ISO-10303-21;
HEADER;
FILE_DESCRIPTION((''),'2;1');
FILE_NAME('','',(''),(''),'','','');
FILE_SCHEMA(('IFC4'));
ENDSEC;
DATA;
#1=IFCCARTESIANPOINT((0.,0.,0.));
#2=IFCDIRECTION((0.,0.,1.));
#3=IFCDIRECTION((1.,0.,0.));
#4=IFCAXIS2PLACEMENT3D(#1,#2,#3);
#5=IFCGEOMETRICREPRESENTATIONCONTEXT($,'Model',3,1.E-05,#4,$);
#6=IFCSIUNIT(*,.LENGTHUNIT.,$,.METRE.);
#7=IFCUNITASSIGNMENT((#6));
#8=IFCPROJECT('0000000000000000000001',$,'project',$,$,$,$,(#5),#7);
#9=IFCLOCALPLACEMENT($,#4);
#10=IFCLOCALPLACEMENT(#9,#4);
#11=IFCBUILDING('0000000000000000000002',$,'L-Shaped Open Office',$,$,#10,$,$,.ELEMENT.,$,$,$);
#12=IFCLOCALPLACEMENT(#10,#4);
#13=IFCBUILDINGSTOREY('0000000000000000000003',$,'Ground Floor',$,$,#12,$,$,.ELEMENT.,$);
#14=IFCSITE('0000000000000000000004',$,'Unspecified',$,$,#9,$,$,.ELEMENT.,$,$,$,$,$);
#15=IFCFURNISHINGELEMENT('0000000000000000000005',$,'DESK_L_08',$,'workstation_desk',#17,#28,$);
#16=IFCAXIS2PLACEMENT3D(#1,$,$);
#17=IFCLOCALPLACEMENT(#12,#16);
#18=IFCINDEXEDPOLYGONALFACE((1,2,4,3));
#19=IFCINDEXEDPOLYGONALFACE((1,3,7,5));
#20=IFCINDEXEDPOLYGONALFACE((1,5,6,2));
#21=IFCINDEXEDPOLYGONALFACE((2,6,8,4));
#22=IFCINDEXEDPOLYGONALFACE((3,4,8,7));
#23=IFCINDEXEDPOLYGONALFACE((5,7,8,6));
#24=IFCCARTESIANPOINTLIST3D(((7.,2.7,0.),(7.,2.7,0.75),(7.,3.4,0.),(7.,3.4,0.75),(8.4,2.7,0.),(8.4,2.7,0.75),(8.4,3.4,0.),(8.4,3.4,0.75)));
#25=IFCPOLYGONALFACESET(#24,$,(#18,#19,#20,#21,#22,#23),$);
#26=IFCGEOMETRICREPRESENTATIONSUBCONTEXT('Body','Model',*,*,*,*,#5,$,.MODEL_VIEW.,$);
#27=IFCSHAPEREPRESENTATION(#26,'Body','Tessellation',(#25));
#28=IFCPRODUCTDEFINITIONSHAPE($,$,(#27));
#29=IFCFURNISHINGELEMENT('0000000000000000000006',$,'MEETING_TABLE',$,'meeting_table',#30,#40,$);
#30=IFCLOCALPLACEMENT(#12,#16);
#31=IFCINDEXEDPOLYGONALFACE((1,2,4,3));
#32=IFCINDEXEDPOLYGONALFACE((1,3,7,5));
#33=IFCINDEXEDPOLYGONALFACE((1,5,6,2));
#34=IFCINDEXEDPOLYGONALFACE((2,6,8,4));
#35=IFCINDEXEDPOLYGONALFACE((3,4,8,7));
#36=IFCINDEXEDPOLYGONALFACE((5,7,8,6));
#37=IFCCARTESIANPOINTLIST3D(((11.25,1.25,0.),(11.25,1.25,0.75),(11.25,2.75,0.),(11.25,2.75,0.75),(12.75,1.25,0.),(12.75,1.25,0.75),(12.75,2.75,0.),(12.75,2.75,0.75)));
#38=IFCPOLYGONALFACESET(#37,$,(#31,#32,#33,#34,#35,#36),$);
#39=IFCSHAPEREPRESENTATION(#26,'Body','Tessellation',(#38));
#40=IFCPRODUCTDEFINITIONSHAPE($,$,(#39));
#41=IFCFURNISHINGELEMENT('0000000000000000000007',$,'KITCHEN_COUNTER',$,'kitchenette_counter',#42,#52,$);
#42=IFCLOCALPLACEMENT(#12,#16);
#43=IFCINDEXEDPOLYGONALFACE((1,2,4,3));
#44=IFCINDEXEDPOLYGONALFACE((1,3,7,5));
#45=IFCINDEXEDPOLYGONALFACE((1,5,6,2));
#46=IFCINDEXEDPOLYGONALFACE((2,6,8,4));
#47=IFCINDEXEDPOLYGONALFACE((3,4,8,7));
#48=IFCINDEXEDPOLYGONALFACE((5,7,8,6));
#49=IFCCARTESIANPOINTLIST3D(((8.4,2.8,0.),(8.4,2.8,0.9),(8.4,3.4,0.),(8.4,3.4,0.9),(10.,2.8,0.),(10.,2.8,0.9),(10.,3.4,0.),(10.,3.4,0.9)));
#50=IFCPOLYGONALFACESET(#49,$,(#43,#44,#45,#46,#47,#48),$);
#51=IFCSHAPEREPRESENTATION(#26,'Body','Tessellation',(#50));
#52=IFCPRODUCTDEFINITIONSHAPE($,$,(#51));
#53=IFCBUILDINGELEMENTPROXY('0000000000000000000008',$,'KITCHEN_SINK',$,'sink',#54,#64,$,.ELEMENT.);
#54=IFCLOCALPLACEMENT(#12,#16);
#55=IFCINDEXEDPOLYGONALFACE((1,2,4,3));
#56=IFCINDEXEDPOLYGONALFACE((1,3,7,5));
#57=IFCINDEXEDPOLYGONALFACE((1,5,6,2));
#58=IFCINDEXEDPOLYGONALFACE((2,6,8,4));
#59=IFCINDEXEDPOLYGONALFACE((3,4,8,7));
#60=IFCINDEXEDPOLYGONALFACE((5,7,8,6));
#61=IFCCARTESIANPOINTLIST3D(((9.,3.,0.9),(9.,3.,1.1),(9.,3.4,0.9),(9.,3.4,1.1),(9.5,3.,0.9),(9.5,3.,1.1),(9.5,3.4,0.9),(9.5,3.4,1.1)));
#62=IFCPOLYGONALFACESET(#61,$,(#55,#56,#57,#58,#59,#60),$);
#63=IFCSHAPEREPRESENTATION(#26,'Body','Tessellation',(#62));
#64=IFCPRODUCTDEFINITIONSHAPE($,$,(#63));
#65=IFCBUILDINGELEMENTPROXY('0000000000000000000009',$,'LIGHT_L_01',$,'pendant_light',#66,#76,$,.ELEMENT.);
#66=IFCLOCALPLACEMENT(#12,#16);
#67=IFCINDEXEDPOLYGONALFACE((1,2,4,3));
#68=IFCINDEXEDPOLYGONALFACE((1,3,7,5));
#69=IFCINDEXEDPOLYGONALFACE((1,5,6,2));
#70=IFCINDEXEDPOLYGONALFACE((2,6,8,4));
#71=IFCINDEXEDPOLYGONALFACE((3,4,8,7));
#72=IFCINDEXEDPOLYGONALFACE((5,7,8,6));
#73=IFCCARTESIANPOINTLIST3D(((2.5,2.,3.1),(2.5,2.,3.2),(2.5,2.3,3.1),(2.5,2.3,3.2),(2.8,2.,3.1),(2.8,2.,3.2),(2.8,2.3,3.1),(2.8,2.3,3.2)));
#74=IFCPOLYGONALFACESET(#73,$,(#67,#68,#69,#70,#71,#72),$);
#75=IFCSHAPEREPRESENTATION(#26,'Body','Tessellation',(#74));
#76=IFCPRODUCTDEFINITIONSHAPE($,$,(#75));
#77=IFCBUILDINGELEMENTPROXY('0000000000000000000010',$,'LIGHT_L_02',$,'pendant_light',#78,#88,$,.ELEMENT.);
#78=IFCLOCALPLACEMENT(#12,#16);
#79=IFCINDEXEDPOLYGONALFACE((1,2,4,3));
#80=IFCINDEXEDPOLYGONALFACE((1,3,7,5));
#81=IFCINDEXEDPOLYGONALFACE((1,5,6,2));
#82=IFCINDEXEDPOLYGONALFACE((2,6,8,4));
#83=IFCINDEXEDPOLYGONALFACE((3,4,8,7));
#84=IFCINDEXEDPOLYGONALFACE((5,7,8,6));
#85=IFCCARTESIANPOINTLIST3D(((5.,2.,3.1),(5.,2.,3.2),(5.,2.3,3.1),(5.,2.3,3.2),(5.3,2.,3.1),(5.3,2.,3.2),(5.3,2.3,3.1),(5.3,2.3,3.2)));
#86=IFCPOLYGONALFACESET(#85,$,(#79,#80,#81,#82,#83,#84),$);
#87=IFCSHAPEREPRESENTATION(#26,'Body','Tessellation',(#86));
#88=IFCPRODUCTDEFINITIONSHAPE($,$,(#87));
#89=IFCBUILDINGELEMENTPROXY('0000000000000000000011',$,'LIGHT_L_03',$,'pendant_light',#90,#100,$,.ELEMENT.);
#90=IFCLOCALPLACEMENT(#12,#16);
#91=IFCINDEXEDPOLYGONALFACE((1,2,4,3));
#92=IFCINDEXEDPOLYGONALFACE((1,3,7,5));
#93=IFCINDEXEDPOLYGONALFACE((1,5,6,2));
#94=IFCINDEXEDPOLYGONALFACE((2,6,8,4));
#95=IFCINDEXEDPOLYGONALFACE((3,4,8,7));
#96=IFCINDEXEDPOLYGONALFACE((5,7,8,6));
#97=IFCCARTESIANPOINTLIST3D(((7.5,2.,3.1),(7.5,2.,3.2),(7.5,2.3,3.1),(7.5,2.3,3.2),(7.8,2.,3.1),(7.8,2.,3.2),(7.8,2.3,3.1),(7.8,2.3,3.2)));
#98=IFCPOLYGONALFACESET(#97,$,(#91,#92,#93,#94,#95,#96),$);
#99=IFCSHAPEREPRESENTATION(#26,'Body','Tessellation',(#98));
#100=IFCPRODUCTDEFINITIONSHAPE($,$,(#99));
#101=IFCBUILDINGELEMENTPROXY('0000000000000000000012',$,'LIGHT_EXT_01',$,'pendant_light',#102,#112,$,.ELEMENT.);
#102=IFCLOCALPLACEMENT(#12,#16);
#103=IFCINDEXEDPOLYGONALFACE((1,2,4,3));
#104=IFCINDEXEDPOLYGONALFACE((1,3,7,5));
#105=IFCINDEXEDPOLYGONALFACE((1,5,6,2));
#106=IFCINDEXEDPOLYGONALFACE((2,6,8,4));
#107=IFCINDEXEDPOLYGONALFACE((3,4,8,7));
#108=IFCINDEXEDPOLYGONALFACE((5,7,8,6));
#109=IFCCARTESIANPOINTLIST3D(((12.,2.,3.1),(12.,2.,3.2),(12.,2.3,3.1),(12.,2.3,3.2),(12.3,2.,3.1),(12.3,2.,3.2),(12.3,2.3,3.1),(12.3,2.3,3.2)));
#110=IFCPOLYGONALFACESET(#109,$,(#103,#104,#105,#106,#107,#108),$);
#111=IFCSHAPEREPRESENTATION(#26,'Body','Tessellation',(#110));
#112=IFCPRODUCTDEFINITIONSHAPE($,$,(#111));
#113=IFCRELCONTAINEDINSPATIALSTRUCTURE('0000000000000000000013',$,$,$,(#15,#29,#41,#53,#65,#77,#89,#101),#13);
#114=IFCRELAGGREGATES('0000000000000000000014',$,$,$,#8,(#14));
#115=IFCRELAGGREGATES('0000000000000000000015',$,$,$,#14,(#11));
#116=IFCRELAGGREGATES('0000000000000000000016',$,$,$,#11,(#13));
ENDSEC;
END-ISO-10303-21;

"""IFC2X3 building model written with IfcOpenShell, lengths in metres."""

from ifc_helpers import new_model, si_unit, frame, frame_2d, origin, origin_with_axes, place, context, subcontext, project, spatial, rectangle, extrude, element, save


model = new_model("IFC2X3")

# Units and contexts
model_context = context("Model", 3, precision=1e-05, world=origin_with_axes())
body_context = subcontext(model_context, "Body", "Model", "MODEL_VIEW")
ifc_project = project(units=[si_unit("LENGTHUNIT", "METRE")], contexts=[model_context])

# Site, building, storey
site_placement = place(None, origin_with_axes())
site = spatial("IfcSite", under=ifc_project, at=site_placement, Name="Unspecified", CompositionType="ELEMENT")
building_placement = place(site_placement, origin_with_axes())
building = spatial("IfcBuilding", under=site, at=building_placement, Name="L-Shaped Open Office", CompositionType="ELEMENT")
storey_placement = place(building_placement, origin_with_axes())
storey = spatial("IfcBuildingStorey", under=building, at=storey_placement, Name="Ground Floor", CompositionType="ELEMENT")

# Furnishing elements
for number, where, z_axis, x_axis, name in (
    (1, (7.0, 2.7, 0.0), (0.0, 0.0, 1.0), (1.0, 0.0, 0.0), "DESK_L_08"),
):
    element("IfcFurnishingElement", number, at=place(storey_placement, frame(where, z_axis=z_axis, x_axis=x_axis)), inside=storey, Name=name, ObjectType="workstation_desk", context=body_context, shape_type="SweptSolid", body=[
        extrude(rectangle(XDim=1.4, YDim=0.7, at=frame_2d((0.7, 0.35))), origin(), (0.0, 0.0, 1.0), 0.75),
    ])
furnishing_1_placement = place(storey_placement, frame((11.25, 1.25, 0.0), z_axis=(0.0, 0.0, 1.0), x_axis=(1.0, 0.0, 0.0)))
element("IfcFurnishingElement", 2, at=furnishing_1_placement, inside=storey, Name="MEETING_TABLE", ObjectType="meeting_table", context=body_context, shape_type="SweptSolid", body=[
    extrude(rectangle(XDim=1.5, YDim=1.5, at=frame_2d((0.75, 0.75))), origin(), (0.0, 0.0, 1.0), 0.75),
])
furnishing_2_placement = place(storey_placement, frame((8.4, 2.8, 0.0), z_axis=(0.0, 0.0, 1.0), x_axis=(1.0, 0.0, 0.0)))
element("IfcFurnishingElement", 3, at=furnishing_2_placement, inside=storey, Name="KITCHEN_COUNTER", ObjectType="kitchenette_counter", context=body_context, shape_type="SweptSolid", body=[
    extrude(rectangle(XDim=1.6, YDim=0.6, at=frame_2d((0.8, 0.3))), origin(), (0.0, 0.0, 1.0), 0.9),
])

# Building element proxies
proxy_placement = place(storey_placement, frame((9.0, 3.0, 0.9), z_axis=(0.0, 0.0, 1.0), x_axis=(1.0, 0.0, 0.0)))
element("IfcBuildingElementProxy", 4, at=proxy_placement, inside=storey, Name="KITCHEN_SINK", ObjectType="sink", CompositionType="ELEMENT", context=body_context, shape_type="SweptSolid", body=[
    extrude(rectangle(XDim=0.5, YDim=0.4, at=frame_2d((0.25, 0.2))), origin(), (0.0, 0.0, 1.0), 0.2),
])
for number, where, z_axis, x_axis, name in (
    (5, (2.5, 2.0, 3.1), (0.0, 0.0, 1.0), (1.0, 0.0, 0.0), "LIGHT_L_01"),
    (6, (5.0, 2.0, 3.1), (0.0, 0.0, 1.0), (1.0, 0.0, 0.0), "LIGHT_L_02"),
    (7, (7.5, 2.0, 3.1), (0.0, 0.0, 1.0), (1.0, 0.0, 0.0), "LIGHT_L_03"),
    (8, (12.0, 2.0, 3.1), (0.0, 0.0, 1.0), (1.0, 0.0, 0.0), "LIGHT_EXT_01"),
):
    element("IfcBuildingElementProxy", number, at=place(storey_placement, frame(where, z_axis=z_axis, x_axis=x_axis)), inside=storey, Name=name, ObjectType="pendant_light", CompositionType="ELEMENT", context=body_context, shape_type="SweptSolid", body=[
        extrude(rectangle(XDim=0.3, YDim=0.3, at=frame_2d((0.15, 0.15))), origin(), (0.0, 0.0, 1.0), 0.1),
    ])

save(model, "model.ifc")
